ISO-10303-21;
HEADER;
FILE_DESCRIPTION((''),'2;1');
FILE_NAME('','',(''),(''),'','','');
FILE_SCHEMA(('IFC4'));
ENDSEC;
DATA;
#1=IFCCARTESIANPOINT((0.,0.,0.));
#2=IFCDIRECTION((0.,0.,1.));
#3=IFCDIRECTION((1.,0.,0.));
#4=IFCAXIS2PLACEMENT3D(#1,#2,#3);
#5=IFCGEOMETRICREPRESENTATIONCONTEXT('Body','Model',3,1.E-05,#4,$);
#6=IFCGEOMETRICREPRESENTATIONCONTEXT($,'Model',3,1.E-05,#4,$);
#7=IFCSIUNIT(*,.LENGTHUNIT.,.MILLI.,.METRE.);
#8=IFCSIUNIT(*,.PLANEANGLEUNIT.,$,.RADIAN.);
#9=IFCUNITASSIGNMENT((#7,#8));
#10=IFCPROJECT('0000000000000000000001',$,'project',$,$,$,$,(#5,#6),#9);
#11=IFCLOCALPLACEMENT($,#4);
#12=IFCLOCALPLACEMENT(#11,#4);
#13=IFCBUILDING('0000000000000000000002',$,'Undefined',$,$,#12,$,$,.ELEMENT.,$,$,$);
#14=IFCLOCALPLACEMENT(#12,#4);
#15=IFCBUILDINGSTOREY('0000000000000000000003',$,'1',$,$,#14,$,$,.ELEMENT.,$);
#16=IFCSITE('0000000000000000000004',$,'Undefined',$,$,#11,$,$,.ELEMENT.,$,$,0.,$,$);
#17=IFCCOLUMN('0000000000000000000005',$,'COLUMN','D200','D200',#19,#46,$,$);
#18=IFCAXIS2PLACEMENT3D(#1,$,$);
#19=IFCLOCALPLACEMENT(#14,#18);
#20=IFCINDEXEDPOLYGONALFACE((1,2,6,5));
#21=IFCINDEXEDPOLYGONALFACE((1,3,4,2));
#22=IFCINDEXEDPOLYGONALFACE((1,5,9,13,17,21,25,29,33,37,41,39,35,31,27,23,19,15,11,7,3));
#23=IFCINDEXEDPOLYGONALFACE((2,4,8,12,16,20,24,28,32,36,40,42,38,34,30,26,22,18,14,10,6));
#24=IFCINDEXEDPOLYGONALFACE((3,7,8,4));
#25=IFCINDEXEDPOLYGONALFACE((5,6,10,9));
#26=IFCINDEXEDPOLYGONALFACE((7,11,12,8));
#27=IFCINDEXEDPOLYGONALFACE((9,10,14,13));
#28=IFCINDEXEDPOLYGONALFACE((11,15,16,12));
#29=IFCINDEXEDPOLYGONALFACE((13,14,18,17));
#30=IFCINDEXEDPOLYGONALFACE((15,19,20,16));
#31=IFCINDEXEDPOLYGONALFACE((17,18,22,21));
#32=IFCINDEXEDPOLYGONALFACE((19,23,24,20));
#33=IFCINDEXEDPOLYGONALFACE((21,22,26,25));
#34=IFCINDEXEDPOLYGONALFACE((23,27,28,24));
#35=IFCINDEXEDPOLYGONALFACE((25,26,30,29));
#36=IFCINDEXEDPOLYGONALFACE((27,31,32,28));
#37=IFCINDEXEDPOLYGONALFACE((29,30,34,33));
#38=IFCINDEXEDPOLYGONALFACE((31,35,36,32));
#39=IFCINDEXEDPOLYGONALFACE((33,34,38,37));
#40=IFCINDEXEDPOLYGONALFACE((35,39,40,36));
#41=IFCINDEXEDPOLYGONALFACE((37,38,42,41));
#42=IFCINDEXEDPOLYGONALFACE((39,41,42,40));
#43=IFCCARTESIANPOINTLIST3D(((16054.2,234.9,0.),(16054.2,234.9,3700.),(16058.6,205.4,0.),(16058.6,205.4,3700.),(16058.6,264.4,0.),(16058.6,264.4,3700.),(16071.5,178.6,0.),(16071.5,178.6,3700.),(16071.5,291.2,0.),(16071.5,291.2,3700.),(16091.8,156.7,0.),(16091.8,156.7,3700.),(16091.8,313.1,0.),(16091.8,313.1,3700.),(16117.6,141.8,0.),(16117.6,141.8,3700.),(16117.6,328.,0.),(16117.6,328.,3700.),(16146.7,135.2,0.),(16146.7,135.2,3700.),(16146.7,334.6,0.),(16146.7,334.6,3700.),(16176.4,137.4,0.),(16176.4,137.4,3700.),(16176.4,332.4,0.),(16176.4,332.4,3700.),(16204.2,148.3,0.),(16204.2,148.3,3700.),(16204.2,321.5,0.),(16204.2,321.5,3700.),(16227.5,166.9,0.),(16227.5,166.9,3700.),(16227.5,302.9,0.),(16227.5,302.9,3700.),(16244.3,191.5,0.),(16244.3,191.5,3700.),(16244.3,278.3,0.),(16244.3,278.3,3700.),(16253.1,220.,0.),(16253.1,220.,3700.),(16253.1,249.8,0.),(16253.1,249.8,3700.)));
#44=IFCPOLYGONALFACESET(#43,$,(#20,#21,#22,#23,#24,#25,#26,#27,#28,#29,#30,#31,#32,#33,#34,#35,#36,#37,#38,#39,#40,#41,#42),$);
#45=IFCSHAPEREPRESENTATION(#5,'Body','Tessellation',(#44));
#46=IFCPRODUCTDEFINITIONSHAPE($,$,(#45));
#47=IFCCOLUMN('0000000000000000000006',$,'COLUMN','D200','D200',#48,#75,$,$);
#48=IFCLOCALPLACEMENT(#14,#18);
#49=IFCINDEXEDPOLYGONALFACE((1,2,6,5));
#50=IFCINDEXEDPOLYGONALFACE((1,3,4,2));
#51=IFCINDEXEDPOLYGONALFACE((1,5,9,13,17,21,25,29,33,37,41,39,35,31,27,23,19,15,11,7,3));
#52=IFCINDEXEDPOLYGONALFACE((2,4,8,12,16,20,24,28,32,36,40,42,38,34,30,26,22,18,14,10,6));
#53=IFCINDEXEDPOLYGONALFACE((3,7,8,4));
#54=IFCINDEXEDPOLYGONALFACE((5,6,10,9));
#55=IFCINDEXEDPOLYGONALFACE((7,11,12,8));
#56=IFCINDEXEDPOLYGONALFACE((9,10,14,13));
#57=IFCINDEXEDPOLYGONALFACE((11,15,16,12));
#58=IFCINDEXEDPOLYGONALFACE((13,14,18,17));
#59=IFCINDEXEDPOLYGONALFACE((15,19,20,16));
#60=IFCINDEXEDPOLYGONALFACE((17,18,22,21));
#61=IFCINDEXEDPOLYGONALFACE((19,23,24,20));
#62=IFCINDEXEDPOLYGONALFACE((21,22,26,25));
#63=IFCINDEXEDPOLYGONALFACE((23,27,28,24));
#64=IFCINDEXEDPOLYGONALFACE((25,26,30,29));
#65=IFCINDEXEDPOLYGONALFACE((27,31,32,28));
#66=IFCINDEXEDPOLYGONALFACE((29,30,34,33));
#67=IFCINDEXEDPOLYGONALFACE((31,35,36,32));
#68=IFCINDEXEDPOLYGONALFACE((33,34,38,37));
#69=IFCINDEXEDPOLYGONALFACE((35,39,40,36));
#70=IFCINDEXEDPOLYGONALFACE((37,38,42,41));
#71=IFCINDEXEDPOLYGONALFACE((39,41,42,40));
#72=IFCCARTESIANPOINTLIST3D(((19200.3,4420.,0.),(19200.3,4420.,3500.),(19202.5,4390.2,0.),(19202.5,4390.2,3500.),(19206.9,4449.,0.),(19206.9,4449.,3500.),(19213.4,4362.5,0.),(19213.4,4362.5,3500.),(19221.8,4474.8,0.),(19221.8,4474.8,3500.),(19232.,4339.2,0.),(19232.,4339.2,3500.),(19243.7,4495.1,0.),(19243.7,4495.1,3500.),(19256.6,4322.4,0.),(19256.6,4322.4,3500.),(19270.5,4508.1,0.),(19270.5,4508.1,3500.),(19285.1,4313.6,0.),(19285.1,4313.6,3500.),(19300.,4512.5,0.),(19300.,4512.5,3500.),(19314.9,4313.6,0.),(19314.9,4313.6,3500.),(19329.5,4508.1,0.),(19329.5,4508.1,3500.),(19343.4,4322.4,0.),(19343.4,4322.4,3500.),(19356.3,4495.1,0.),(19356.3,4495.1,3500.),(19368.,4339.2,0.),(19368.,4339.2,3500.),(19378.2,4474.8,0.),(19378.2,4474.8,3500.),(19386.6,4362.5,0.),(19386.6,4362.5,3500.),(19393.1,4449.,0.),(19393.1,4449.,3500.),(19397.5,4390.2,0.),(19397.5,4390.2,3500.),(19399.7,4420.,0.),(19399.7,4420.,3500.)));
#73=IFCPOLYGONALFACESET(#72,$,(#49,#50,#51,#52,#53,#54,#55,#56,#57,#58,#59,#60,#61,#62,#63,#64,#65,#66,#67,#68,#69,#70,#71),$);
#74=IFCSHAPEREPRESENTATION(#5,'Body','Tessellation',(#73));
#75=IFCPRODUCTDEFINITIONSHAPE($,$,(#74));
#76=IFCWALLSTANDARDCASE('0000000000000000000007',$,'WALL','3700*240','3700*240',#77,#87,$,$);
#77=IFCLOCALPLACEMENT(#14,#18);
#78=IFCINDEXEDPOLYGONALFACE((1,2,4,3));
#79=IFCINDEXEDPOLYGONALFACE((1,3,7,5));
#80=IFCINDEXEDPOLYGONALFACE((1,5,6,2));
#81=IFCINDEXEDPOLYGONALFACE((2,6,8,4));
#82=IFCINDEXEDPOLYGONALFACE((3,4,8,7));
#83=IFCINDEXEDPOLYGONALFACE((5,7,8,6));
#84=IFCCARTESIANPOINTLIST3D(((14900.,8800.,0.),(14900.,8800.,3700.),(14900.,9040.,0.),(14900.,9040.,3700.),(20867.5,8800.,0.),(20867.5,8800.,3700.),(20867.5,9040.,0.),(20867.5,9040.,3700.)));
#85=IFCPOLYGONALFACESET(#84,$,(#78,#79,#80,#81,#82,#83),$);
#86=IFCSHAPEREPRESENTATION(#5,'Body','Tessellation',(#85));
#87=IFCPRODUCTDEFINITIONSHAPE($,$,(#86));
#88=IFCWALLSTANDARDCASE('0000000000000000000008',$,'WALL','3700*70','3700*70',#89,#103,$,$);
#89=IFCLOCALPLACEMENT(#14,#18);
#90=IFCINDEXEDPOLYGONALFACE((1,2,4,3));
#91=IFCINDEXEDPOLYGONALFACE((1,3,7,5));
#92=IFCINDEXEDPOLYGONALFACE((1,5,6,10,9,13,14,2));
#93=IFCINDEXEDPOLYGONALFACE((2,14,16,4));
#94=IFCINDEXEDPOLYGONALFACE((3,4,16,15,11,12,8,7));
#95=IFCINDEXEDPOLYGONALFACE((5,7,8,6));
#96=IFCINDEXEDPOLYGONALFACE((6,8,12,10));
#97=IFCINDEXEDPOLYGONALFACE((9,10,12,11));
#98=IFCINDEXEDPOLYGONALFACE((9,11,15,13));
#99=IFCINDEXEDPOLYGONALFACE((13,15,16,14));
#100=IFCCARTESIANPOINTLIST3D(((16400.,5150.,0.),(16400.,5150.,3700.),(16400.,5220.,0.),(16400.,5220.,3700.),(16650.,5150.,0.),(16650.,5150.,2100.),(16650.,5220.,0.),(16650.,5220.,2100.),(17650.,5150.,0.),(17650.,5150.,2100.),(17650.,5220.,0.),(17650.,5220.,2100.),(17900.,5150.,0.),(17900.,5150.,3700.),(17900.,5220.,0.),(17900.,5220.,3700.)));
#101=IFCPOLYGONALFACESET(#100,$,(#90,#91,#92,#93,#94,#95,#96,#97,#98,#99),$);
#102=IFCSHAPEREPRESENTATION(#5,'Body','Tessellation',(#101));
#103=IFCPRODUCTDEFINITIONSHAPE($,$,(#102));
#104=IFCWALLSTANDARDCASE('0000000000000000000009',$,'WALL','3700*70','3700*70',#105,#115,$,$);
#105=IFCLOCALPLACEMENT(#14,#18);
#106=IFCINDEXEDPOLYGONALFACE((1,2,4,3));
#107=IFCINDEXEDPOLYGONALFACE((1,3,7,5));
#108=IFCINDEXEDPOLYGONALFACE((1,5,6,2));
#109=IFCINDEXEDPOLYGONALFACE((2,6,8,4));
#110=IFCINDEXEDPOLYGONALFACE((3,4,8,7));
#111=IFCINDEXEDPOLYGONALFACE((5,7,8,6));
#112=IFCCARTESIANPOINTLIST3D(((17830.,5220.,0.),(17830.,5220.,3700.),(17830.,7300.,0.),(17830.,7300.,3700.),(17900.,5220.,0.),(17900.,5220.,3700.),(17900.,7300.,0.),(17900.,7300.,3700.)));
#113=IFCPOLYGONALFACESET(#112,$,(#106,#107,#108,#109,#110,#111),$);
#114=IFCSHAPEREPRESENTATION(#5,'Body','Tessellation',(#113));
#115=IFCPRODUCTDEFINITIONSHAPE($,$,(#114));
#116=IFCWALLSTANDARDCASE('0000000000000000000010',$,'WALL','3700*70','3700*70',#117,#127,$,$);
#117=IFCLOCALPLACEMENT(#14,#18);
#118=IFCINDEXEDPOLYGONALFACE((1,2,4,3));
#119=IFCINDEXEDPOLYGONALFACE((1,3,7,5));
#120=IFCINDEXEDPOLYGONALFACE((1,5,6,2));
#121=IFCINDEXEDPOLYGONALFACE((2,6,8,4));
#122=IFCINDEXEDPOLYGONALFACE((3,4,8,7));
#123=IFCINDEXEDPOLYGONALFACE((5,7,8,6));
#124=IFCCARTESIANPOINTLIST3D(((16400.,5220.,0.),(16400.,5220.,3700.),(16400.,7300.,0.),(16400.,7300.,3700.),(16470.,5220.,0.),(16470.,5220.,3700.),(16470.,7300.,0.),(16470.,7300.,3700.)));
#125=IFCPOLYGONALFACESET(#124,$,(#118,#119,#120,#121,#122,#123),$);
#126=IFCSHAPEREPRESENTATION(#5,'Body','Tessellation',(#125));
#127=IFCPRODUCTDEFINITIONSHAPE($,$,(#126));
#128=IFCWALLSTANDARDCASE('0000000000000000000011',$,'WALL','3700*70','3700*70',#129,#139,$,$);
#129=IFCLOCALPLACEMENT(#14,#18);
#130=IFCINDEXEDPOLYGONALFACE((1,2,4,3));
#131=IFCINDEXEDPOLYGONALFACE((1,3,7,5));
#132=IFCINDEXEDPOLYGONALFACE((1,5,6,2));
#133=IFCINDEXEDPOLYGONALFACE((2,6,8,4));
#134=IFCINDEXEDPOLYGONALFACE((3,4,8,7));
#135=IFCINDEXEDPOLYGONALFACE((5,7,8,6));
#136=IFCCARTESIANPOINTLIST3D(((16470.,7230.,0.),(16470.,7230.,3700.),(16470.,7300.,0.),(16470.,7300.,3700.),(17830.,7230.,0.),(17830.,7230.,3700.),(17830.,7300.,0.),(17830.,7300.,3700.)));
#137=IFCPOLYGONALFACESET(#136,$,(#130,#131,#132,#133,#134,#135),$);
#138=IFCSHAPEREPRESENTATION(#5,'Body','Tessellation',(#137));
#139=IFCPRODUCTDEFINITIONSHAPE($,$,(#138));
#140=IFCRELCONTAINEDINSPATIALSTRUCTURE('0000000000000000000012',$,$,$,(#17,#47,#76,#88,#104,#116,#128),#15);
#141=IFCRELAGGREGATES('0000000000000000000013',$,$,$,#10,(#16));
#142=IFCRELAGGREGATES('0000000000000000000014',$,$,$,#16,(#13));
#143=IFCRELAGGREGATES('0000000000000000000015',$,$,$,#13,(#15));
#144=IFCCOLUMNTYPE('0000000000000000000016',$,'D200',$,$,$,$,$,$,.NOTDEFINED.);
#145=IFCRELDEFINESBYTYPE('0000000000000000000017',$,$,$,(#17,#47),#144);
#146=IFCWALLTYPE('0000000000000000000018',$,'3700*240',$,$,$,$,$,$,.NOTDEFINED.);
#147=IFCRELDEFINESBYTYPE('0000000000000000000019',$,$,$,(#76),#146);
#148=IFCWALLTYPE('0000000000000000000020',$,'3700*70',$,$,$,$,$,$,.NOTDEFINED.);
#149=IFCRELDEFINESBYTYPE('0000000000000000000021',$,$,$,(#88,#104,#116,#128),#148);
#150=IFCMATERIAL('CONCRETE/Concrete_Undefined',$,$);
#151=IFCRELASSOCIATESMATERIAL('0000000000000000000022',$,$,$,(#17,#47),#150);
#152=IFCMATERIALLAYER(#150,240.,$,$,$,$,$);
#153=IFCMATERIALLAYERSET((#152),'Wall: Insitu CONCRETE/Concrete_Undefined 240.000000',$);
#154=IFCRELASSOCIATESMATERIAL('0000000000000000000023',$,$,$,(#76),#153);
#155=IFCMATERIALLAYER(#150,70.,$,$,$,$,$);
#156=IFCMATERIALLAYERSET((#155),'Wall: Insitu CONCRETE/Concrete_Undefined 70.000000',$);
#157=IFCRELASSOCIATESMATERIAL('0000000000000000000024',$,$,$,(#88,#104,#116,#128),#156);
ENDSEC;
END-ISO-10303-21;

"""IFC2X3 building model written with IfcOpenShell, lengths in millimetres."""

from ifc_helpers import new_model, si_unit, frame, frame_2d, origin_with_axes, origin_2d_with_axis, place, context, project, spatial, polyline, rectangle, circle, outline, extrude, material, layer, layer_set, layer_usage, type_object, element, save


model = new_model("IFC2X3")

# Units and contexts
model_context_1 = context("Model", 3, precision=1e-05, world=origin_with_axes(), identifier="Body")
model_context_2 = context("Model", 3, precision=1e-05, world=origin_with_axes())
ifc_project = project(units=[si_unit("LENGTHUNIT", "METRE", prefix="MILLI"), si_unit("PLANEANGLEUNIT", "RADIAN")], contexts=[model_context_1, model_context_2])

# Site, building, storey
site_placement = place(None, origin_with_axes())
site = spatial("IfcSite", under=ifc_project, at=site_placement, Name="Undefined", CompositionType="ELEMENT", RefElevation=0.0)
building_placement = place(site_placement, origin_with_axes())
building = spatial("IfcBuilding", under=site, at=building_placement, Name="Undefined", CompositionType="ELEMENT")
storey_placement = place(building_placement, origin_with_axes())
storey = spatial("IfcBuildingStorey", under=building, at=storey_placement, Name="1", CompositionType="ELEMENT")

# Columns
ifc_material = material(Name="CONCRETE/Concrete_Undefined")
column_type_1 = type_object("IfcColumnType", Name="D200", PredefinedType="NOTDEFINED")
for number, where, z_axis, x_axis, name in (
    (1, (16154.2, 234.9, 0.0), (0.0, 0.0, 1.0), (1.0, 0.0, 0.0), "COLUMN"),
):
    element("IfcColumn", number, at=place(storey_placement, frame(where, z_axis=z_axis, x_axis=x_axis)), inside=storey, type_object=column_type_1, material=ifc_material, Name=name, Description="D200", ObjectType="D200", context=model_context_1, shape_type="SweptSolid", body=[
        extrude(circle(Radius=100.0, at=origin_2d_with_axis()), frame((0.0, 0.0, 3700.0), z_axis=(0.0, 0.0, -1.0), x_axis=(-1.0, 0.0, 0.0)), (0.0, 0.0, 1.0), 3700.0),
    ])
column_1_placement = place(storey_placement, frame((19300.0, 4412.5, 0.0), z_axis=(0.0, 0.0, 1.0), x_axis=(1.0, 0.0, 0.0)))
element("IfcColumn", 2, at=column_1_placement, inside=storey, type_object=column_type_1, material=ifc_material, Name="COLUMN", Description="D200", ObjectType="D200", context=model_context_1, shape_type="SweptSolid", body=[
    extrude(circle(Radius=100.0, at=origin_2d_with_axis()), frame((0.0, 0.0, 3500.0), z_axis=(0.0, 0.0, -1.0), x_axis=(0.0, 1.0, 0.0)), (0.0, 0.0, 1.0), 3500.0),
])

# Shared definitions
ifc_layer_1 = layer(ifc_material, 240.0)
ifc_layer_set_1 = layer_set([ifc_layer_1], Name="Wall: Insitu CONCRETE/Concrete_Undefined 240.000000")

# Wall
ifc_layer_usage_1 = layer_usage(ifc_layer_set_1, "AXIS2", "POSITIVE", -120.0)
wall_type_1 = type_object("IfcWallType", Name="3700*240", PredefinedType="NOTDEFINED")
wall_1_placement = place(storey_placement, frame((20867.5, 8920.0, 0.0), z_axis=(0.0, 0.0, 1.0), x_axis=(-1.0, 0.0, 0.0)))
element("IfcWallStandardCase", 3, at=wall_1_placement, inside=storey, type_object=wall_type_1, material=ifc_layer_usage_1, Name="WALL", Description="3700*240", ObjectType="3700*240", context=model_context_1, shape_type="SweptSolid", body=[
    extrude(rectangle(XDim=5967.5, YDim=240.0, at=frame_2d((0.0, 2983.8), x_axis=(0.0, -1.0))), frame((0.0, 0.0, 0.0), z_axis=(0.0, 0.0, 1.0), x_axis=(0.0, -1.0, 0.0)), (0.0, 0.0, 1.0), 3700.0),
])

# Wall, opening
ifc_layer_2 = layer(ifc_material, 70.0)
ifc_layer_set_2 = layer_set([ifc_layer_2], Name="Wall: Insitu CONCRETE/Concrete_Undefined 70.000000")
ifc_layer_usage_2 = layer_usage(ifc_layer_set_2, "AXIS2", "POSITIVE", -35.0)
wall_type_2 = type_object("IfcWallType", Name="3700*70", PredefinedType="NOTDEFINED")
wall_2_placement = place(storey_placement, frame((16400.0, 5185.0, 0.0), z_axis=(0.0, 0.0, 1.0), x_axis=(1.0, 0.0, 0.0)))
wall_2 = element("IfcWallStandardCase", 4, at=wall_2_placement, inside=storey, type_object=wall_type_2, material=ifc_layer_usage_2, Name="WALL", Description="3700*70", ObjectType="3700*70", context=model_context_1, shape_type="SweptSolid", body=[
    extrude(rectangle(XDim=1500.0, YDim=70.0, at=frame_2d((0.0, 750.0), x_axis=(0.0, -1.0))), frame((0.0, 0.0, 0.0), z_axis=(0.0, 0.0, 1.0), x_axis=(0.0, -1.0, 0.0)), (0.0, 0.0, 1.0), 3700.0),
])
opening_1_placement = place(storey_placement, frame((16400.0, 5185.0, 0.0), z_axis=(0.0, 0.0, 1.0), x_axis=(1.0, 0.0, 0.0)))
element("IfcOpeningElement", 5, at=opening_1_placement, cuts=wall_2, ObjectType="Recess", context=model_context_1, shape_type="SweptSolid", body=[
    extrude(outline(polyline([(0.0, 0.0), (1000.0, 0.0), (1000.0, 2100.0), (0.0, 2100.0), (0.0, 0.0)])), frame((250.0, -38.0, 2100.0), z_axis=(0.0, 1.0, 0.0), x_axis=(1.0, 0.0, 0.0)), (0.0, 0.0, 1.0), 76.0),
])

# Walls
ifc_layer_usage_3 = layer_usage(ifc_layer_set_2, "AXIS2", "POSITIVE", -35.0)
wall_3_placement = place(storey_placement, frame((17865.0, 5220.0, 0.0), z_axis=(0.0, 0.0, 1.0), x_axis=(0.0, 1.0, 0.0)))
element("IfcWallStandardCase", 6, at=wall_3_placement, inside=storey, type_object=wall_type_2, material=ifc_layer_usage_3, Name="WALL", Description="3700*70", ObjectType="3700*70", context=model_context_1, shape_type="SweptSolid", body=[
    extrude(rectangle(XDim=2080.0, YDim=70.0, at=frame_2d((0.0, 1040.0), x_axis=(0.0, -1.0))), frame((0.0, 0.0, 0.0), z_axis=(0.0, 0.0, 1.0), x_axis=(0.0, -1.0, 0.0)), (0.0, 0.0, 1.0), 3700.0),
])
ifc_layer_usage_4 = layer_usage(ifc_layer_set_2, "AXIS2", "POSITIVE", -35.0)
wall_4_placement = place(storey_placement, frame((16435.0, 7300.0, 0.0), z_axis=(0.0, 0.0, 1.0), x_axis=(0.0, -1.0, 0.0)))
element("IfcWallStandardCase", 7, at=wall_4_placement, inside=storey, type_object=wall_type_2, material=ifc_layer_usage_4, Name="WALL", Description="3700*70", ObjectType="3700*70", context=model_context_1, shape_type="SweptSolid", body=[
    extrude(rectangle(XDim=2080.0, YDim=70.0, at=frame_2d((0.0, 1040.0), x_axis=(0.0, -1.0))), frame((0.0, 0.0, 0.0), z_axis=(0.0, 0.0, 1.0), x_axis=(0.0, -1.0, 0.0)), (0.0, 0.0, 1.0), 3700.0),
])
ifc_layer_usage_5 = layer_usage(ifc_layer_set_2, "AXIS2", "POSITIVE", -35.0)
wall_5_placement = place(storey_placement, frame((17830.0, 7265.0, 0.0), z_axis=(0.0, 0.0, 1.0), x_axis=(-1.0, 0.0, 0.0)))
element("IfcWallStandardCase", 8, at=wall_5_placement, inside=storey, type_object=wall_type_2, material=ifc_layer_usage_5, Name="WALL", Description="3700*70", ObjectType="3700*70", context=model_context_1, shape_type="SweptSolid", body=[
    extrude(rectangle(XDim=1360.0, YDim=70.0, at=frame_2d((0.0, 680.0), x_axis=(0.0, -1.0))), frame((0.0, 0.0, 0.0), z_axis=(0.0, 0.0, 1.0), x_axis=(0.0, -1.0, 0.0)), (0.0, 0.0, 1.0), 3700.0),
])

save(model, "model.ifc")
